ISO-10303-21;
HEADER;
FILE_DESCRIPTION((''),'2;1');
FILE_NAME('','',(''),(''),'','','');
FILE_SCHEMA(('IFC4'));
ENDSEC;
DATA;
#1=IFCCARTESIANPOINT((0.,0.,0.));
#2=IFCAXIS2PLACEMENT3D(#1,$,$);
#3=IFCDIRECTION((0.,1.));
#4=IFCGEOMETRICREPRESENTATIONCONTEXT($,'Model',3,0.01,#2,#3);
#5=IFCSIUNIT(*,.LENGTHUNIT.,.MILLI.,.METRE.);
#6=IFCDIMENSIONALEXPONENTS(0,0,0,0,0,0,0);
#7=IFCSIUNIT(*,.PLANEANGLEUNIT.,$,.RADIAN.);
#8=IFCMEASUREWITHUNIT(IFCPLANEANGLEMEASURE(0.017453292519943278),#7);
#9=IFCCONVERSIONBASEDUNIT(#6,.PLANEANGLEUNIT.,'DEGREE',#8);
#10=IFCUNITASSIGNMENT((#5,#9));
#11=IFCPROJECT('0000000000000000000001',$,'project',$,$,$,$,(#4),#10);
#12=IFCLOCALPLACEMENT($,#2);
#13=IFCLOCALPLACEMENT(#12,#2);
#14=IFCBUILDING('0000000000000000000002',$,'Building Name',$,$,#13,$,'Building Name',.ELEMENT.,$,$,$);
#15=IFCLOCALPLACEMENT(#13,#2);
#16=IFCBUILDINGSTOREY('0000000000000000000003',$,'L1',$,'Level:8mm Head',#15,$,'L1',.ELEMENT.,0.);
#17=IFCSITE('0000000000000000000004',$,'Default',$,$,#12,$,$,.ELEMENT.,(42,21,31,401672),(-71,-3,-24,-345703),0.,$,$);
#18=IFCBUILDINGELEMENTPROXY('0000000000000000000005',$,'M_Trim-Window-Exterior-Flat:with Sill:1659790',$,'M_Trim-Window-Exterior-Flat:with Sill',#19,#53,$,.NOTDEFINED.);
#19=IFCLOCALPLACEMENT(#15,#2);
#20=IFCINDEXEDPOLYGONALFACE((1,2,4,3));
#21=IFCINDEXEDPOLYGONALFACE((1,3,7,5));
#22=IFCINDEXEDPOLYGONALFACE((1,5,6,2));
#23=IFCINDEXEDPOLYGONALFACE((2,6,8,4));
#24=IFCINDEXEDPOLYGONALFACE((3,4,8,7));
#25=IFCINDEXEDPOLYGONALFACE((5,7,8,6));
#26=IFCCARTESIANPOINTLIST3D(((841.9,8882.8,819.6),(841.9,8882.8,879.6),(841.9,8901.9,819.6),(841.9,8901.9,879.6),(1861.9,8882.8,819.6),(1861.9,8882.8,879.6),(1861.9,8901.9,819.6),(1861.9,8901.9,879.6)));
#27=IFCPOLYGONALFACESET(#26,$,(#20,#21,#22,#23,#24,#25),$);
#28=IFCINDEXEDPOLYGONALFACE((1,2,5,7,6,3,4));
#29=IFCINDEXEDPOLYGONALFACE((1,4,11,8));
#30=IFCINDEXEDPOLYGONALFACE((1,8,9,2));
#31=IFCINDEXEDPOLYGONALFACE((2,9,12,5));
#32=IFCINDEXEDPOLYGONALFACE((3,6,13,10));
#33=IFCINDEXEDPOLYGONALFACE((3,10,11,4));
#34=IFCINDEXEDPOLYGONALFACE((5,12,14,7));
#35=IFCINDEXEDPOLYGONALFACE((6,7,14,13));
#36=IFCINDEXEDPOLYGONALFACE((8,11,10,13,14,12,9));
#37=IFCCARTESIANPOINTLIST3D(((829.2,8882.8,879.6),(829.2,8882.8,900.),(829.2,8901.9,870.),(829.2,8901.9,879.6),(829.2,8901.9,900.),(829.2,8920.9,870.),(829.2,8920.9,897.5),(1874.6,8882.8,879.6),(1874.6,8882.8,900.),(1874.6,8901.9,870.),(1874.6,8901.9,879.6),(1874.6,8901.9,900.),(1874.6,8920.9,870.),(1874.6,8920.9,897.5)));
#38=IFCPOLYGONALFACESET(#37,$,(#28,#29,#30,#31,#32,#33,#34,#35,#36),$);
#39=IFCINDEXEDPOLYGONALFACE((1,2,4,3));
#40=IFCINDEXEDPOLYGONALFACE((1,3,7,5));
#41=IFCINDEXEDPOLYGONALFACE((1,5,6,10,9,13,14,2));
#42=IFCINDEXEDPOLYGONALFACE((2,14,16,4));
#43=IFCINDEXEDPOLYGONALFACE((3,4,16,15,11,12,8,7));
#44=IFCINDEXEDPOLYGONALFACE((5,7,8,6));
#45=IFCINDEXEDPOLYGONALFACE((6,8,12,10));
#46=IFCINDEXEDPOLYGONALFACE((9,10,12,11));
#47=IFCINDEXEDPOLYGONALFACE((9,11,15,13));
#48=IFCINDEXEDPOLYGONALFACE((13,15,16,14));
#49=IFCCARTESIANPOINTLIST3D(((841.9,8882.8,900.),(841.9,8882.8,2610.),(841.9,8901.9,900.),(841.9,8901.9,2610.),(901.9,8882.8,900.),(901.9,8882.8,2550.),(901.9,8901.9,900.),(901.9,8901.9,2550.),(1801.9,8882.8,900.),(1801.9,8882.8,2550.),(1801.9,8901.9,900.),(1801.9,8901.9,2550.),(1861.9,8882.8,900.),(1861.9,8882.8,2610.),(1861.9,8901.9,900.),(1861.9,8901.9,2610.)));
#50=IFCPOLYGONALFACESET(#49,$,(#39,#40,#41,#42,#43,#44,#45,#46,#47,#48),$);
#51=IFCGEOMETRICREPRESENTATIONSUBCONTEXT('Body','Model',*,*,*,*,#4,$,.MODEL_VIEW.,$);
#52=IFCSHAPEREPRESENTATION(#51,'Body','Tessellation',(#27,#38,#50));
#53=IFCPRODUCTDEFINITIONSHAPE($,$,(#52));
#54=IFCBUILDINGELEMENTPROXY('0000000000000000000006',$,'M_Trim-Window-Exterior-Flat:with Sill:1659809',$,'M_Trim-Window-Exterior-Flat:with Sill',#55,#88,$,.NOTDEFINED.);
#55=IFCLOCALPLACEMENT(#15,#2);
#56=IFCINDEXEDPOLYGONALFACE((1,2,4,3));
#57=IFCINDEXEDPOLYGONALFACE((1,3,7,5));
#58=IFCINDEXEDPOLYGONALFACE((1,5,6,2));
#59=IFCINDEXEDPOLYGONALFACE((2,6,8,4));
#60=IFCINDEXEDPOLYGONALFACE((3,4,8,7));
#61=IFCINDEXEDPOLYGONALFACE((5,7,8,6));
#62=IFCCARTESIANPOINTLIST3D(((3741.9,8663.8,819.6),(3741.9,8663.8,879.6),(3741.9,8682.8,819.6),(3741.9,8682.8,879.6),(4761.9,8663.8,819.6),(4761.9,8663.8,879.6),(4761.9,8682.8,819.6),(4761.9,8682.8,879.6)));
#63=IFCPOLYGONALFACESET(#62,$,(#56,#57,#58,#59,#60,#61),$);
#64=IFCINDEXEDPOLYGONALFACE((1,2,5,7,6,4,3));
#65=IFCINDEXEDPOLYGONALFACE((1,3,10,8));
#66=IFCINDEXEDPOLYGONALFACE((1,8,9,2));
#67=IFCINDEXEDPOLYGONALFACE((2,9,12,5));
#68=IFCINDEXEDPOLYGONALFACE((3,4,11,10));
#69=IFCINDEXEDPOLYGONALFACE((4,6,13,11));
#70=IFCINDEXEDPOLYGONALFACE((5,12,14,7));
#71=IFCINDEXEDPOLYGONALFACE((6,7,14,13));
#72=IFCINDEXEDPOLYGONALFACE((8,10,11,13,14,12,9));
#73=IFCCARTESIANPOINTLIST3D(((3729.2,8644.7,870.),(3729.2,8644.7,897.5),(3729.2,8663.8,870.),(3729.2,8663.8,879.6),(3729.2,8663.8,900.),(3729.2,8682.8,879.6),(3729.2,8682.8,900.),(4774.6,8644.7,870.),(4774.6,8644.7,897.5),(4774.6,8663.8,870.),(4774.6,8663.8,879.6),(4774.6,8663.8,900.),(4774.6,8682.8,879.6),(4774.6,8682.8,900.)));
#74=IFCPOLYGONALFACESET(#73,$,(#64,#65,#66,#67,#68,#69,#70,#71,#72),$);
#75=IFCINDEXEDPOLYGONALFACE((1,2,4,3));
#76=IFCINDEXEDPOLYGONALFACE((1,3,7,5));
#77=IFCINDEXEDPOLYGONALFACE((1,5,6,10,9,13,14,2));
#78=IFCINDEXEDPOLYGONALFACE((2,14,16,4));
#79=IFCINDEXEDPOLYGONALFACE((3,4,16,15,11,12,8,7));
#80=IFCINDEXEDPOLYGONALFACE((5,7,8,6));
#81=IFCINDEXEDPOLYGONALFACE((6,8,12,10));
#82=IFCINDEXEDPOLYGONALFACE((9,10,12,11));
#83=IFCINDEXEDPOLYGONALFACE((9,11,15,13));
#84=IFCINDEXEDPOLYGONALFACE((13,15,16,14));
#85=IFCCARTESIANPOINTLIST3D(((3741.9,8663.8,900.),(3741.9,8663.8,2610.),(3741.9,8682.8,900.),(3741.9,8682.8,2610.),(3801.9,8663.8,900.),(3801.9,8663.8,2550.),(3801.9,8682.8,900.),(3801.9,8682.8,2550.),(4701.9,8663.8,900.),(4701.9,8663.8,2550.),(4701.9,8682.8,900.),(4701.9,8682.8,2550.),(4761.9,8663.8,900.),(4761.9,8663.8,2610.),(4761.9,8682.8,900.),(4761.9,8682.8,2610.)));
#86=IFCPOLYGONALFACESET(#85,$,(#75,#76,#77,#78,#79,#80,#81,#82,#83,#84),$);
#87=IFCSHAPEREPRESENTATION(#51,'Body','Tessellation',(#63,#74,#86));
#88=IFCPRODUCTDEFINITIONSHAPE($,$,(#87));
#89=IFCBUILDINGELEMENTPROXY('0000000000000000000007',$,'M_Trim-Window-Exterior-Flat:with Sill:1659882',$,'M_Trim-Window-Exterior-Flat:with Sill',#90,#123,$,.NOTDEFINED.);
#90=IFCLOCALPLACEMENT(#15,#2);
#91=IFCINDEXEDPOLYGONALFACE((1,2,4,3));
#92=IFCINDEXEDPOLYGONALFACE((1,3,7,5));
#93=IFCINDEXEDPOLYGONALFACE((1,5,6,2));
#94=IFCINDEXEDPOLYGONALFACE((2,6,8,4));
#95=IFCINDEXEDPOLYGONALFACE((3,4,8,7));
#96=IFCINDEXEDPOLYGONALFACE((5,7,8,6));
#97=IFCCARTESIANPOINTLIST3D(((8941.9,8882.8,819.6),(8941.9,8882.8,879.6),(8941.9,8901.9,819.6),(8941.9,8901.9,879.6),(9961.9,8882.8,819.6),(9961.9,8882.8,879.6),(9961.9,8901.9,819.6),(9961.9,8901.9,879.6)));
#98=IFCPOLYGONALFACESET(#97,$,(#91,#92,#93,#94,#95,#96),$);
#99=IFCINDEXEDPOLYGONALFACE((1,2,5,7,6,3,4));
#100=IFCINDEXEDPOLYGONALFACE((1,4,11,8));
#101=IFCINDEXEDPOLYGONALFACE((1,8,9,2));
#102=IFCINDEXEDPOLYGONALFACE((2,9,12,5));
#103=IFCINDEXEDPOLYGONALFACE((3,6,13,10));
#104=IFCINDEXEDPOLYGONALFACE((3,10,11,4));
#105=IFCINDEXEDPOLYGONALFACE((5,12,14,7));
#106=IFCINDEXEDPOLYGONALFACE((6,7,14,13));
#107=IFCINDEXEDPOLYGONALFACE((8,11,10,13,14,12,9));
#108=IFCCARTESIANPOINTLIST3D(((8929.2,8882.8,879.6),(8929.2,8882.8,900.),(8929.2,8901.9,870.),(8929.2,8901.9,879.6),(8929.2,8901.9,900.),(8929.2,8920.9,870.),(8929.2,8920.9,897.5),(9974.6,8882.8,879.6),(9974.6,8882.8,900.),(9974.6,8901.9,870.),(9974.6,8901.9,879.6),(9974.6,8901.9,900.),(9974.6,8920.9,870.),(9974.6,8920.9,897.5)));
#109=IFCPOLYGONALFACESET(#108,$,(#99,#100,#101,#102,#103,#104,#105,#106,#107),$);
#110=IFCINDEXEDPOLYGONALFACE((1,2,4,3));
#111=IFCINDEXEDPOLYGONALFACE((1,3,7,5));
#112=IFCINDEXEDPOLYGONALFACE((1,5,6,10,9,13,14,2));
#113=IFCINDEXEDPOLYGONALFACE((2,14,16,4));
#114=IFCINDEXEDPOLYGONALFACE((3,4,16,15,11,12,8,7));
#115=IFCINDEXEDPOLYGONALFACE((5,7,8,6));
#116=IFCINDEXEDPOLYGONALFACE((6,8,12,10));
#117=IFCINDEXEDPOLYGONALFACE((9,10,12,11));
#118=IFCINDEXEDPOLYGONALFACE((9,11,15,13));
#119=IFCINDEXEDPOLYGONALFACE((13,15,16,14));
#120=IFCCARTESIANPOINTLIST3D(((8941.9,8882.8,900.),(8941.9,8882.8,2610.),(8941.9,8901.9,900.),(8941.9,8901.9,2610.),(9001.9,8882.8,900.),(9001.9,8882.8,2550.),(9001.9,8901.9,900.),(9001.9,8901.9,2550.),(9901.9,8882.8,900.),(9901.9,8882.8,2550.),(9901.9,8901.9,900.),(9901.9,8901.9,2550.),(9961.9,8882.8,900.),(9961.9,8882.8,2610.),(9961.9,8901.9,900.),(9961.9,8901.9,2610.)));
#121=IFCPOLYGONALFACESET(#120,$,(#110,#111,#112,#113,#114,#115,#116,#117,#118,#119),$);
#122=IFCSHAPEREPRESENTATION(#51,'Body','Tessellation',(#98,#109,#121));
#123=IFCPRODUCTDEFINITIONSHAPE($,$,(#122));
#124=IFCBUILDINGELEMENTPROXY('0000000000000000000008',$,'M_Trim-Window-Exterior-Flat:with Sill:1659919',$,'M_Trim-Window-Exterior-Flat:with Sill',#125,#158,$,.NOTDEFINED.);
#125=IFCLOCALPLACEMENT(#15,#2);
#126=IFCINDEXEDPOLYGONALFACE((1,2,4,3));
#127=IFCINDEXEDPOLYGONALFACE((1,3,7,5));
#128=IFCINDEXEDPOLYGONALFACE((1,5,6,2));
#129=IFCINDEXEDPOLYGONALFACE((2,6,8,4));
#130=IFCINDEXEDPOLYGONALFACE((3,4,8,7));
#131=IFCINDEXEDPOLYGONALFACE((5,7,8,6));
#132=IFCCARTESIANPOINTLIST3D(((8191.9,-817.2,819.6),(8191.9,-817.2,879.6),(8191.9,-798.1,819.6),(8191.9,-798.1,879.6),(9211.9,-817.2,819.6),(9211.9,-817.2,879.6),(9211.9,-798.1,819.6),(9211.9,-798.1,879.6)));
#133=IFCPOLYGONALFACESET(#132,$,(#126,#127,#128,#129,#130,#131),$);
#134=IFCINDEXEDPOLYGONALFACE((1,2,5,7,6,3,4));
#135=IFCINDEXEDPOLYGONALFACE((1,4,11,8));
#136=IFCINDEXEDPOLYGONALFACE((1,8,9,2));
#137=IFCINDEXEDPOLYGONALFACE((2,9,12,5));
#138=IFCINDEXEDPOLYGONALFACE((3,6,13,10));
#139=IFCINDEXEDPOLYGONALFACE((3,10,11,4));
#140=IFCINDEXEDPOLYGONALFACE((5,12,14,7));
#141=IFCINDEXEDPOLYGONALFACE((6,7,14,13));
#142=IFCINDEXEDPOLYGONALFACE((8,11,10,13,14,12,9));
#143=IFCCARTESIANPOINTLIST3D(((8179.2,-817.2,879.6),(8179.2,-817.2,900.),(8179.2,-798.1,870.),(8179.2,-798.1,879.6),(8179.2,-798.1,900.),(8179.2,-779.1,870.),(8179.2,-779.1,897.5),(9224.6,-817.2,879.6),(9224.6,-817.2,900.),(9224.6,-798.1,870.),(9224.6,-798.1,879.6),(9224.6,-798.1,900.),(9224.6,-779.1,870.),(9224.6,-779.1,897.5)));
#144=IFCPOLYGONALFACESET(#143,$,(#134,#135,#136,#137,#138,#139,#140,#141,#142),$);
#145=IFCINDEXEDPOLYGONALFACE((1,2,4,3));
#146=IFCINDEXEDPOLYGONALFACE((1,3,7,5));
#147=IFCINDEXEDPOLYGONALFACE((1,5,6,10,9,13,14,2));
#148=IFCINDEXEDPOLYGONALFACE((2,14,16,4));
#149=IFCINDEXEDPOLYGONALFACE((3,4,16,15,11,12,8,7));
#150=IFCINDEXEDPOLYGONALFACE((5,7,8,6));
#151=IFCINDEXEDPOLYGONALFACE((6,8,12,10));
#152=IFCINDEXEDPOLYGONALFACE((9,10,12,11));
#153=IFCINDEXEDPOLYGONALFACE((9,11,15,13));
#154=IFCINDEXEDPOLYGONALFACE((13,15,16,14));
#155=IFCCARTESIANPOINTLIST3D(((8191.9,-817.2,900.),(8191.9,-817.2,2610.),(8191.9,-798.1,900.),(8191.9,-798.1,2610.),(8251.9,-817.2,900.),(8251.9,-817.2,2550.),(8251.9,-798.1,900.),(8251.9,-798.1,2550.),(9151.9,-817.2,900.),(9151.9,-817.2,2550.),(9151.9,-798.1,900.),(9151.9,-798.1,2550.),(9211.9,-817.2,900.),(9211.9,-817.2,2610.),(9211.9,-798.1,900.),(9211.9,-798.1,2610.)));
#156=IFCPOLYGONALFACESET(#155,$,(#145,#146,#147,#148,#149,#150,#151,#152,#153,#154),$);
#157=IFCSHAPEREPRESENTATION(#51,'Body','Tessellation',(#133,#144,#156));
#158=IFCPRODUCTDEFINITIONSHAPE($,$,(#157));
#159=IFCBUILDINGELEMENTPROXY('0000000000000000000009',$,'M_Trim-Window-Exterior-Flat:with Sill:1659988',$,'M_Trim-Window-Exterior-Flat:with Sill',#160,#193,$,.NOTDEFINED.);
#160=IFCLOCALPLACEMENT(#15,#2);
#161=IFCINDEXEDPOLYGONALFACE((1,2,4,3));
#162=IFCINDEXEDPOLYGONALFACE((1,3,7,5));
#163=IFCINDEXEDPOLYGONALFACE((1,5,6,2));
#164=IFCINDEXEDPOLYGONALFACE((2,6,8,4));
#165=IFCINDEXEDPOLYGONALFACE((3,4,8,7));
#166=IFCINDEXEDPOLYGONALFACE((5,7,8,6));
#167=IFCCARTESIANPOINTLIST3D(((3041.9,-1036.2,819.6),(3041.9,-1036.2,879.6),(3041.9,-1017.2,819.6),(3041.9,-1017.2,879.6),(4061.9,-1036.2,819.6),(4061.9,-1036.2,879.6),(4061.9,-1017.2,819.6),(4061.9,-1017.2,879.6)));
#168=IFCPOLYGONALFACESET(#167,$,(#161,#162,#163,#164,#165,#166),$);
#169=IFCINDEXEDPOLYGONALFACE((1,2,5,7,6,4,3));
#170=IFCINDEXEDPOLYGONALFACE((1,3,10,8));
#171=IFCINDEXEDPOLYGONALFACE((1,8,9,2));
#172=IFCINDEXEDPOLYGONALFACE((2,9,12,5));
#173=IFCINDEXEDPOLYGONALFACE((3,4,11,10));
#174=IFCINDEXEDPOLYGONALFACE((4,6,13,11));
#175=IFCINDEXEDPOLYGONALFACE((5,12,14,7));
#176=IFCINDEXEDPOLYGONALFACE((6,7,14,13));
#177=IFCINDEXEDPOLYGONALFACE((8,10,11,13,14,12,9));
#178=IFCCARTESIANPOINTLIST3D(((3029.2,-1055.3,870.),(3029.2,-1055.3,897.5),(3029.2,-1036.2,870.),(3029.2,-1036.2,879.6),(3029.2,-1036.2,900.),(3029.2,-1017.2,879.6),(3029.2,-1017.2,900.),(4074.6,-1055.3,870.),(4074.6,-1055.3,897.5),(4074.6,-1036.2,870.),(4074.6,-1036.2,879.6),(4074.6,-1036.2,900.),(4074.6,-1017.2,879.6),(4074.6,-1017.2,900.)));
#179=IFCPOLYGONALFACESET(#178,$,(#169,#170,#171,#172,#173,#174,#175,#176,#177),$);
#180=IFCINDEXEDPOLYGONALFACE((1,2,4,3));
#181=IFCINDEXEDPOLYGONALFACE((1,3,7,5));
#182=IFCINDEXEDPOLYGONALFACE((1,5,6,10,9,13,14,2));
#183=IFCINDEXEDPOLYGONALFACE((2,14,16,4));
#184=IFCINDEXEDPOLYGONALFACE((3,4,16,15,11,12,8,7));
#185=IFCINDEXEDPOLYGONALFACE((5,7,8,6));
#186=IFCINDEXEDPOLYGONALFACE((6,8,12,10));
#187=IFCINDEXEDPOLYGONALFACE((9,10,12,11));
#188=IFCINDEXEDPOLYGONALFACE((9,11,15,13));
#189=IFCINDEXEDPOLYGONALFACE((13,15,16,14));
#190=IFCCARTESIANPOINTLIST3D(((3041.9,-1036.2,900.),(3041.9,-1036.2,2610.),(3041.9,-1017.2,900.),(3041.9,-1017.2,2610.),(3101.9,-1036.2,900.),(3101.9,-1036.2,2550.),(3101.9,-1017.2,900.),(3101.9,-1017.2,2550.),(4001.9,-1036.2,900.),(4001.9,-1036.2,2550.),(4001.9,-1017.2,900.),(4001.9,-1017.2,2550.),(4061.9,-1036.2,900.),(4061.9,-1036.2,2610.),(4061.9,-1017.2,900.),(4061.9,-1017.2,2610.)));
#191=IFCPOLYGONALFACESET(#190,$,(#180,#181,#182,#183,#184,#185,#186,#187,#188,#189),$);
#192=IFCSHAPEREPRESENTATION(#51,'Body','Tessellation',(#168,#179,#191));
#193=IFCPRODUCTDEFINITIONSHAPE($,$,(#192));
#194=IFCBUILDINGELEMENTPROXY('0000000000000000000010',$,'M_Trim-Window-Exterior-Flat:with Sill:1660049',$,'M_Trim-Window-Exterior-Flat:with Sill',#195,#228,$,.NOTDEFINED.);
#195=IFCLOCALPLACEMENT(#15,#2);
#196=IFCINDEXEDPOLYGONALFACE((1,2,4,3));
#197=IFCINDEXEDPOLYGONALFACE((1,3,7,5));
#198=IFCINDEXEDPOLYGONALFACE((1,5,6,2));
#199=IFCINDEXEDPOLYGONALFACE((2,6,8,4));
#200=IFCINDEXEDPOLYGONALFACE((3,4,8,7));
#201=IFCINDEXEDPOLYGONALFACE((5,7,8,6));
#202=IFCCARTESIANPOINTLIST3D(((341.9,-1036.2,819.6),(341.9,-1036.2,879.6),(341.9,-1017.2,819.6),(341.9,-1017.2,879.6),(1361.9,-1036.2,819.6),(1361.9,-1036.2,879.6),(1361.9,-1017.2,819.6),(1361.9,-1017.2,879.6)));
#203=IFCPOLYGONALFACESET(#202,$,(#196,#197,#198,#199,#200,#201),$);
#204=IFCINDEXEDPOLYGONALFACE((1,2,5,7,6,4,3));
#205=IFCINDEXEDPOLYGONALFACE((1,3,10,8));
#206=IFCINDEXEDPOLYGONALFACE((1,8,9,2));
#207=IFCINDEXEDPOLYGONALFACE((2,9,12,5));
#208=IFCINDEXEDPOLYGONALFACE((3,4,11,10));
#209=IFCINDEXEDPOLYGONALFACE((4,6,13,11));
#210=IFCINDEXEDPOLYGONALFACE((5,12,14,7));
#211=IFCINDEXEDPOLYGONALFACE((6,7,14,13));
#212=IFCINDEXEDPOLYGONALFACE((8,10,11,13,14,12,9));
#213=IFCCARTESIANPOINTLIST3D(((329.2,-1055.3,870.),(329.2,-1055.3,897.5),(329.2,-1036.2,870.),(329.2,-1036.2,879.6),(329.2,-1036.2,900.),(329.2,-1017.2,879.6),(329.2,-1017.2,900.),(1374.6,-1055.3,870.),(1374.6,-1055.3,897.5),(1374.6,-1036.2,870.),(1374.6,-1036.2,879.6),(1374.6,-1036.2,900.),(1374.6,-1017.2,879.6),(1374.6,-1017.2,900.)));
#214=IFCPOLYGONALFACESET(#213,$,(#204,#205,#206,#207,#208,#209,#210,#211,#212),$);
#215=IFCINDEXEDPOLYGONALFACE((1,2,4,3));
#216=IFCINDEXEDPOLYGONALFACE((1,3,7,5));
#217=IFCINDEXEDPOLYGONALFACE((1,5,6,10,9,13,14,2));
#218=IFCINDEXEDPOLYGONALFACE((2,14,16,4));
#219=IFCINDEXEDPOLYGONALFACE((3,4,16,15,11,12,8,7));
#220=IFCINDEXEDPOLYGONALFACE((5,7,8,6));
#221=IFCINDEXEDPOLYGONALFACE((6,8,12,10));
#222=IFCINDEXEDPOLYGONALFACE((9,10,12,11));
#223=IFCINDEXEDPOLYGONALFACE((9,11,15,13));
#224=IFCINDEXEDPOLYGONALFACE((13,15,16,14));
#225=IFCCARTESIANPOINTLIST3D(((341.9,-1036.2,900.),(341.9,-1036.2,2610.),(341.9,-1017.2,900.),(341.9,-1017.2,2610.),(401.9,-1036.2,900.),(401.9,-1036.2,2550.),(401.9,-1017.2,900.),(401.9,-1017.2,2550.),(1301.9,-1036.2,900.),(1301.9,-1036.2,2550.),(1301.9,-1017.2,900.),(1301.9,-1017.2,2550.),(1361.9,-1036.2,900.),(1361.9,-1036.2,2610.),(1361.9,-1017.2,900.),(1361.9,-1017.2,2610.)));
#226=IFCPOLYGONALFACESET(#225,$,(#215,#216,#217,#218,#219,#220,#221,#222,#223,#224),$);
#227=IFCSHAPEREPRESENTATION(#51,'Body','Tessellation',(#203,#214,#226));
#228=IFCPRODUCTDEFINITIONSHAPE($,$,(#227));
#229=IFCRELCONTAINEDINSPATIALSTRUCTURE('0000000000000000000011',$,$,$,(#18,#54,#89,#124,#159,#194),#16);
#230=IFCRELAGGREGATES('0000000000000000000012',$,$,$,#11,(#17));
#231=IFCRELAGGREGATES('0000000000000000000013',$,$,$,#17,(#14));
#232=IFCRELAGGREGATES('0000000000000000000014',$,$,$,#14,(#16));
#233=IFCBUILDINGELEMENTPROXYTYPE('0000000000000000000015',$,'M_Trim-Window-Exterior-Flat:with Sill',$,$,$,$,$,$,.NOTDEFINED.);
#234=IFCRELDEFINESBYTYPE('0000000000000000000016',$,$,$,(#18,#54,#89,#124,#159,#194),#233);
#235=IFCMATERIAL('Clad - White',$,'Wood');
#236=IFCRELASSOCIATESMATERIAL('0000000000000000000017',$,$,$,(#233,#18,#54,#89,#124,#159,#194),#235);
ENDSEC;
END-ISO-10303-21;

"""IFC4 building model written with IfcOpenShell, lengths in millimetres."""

from ifc_helpers import new_model, entity, si_unit, converted_unit, direction, frame, origin, place, context, subcontext, project, spatial, indexed_curve, outline, extrude, source, transform, mapped, material, type_object, type_shapes, element, save


model = new_model("IFC4")

# Units and contexts
model_context = context("Model", 3, precision=0.01, world=origin(), true_north=direction((0.0, 1.0)))
body_context = subcontext(model_context, "Body", "Model", "MODEL_VIEW")
ifc_project = project(units=[si_unit("LENGTHUNIT", "METRE", prefix="MILLI"), converted_unit("PLANEANGLEUNIT", "DEGREE", entity("IfcPlaneAngleMeasure", 0.017453292519943278), si_unit("PLANEANGLEUNIT", "RADIAN"), dimensions=[0, 0, 0, 0, 0, 0, 0])], contexts=[model_context])

# Site, building, storey
site_placement = place(None, origin())
site = spatial("IfcSite", under=ifc_project, at=site_placement, Name="Default", CompositionType="ELEMENT", RefLatitude=(42, 21, 31, 401672), RefLongitude=(-71, -3, -24, -345703), RefElevation=0.0)
building_placement = place(site_placement, origin())
building = spatial("IfcBuilding", under=site, at=building_placement, Name="Building Name", LongName="Building Name", CompositionType="ELEMENT")
storey_placement = place(building_placement, origin())
storey = spatial("IfcBuildingStorey", under=building, at=storey_placement, Name="L1", ObjectType="Level:8mm Head", LongName="L1", CompositionType="ELEMENT", Elevation=0.0)

# Building element proxies
ifc_material_1 = material(Name="Clad - White", Category="Wood")
building_element_proxy_type_1 = type_object("IfcBuildingElementProxyType", Name="M_Trim-Window-Exterior-Flat:with Sill", PredefinedType="NOTDEFINED", material=ifc_material_1)
shared_shape_1 = source(origin(), body_context, "Body", "SweptSolid", [
    extrude(outline(indexed_curve([(-510.0, -30.0), (510.0, -30.0), (510.0, 30.0), (-510.0, 30.0), (-510.0, -30.0)], self_intersect=False)), frame((0.0, -1700.4, 0.0), z_axis=(0.0, 0.0, 1.0), x_axis=(-1.0, 0.0, 0.0)), (0.0, 0.0, 1.0), 19.0),
    extrude(outline(indexed_curve([(-19.0, -15.2), (0.0, -15.2), (0.0, -5.7), (19.0, -5.7), (19.0, 14.8), (0.0, 14.8), (-19.0, 12.3), (-19.0, -15.2)], self_intersect=False)), frame((-522.7, -1664.8, 19.0), z_axis=(1.0, 0.0, 0.0), x_axis=(0.0, 0.0, -1.0)), (0.0, 0.0, 1.0), 1045.4),
    extrude(outline(indexed_curve([(-870.0, -510.0), (840.0, -510.0), (840.0, -450.0), (-810.0, -450.0), (-810.0, 450.0), (840.0, 450.0), (840.0, 510.0), (-870.0, 510.0), (-870.0, -510.0)], self_intersect=False)), frame((0.0, -810.0, 0.0), z_axis=(0.0, 0.0, 1.0), x_axis=(0.0, -1.0, 0.0)), (0.0, 0.0, 1.0), 19.0),
])
type_shapes(building_element_proxy_type_1, [shared_shape_1])
for number, where, z_axis, x_axis, name in (
    (1, (1351.9, 8882.8, 2550.0), (0.0, 1.0, 0.0), (-1.0, 0.0, 0.0), "M_Trim-Window-Exterior-Flat:with Sill:1659790"),
    (2, (4251.9, 8682.8, 2550.0), (0.0, -1.0, 0.0), (1.0, 0.0, 0.0), "M_Trim-Window-Exterior-Flat:with Sill:1659809"),
    (3, (9451.9, 8882.8, 2550.0), (0.0, 1.0, 0.0), (-1.0, 0.0, 0.0), "M_Trim-Window-Exterior-Flat:with Sill:1659882"),
    (4, (8701.9, -817.2, 2550.0), (0.0, 1.0, 0.0), (-1.0, 0.0, 0.0), "M_Trim-Window-Exterior-Flat:with Sill:1659919"),
    (5, (3551.9, -1017.2, 2550.0), (0.0, -1.0, 0.0), (1.0, 0.0, 0.0), "M_Trim-Window-Exterior-Flat:with Sill:1659988"),
    (6, (851.9, -1017.2, 2550.0), (0.0, -1.0, 0.0), (1.0, 0.0, 0.0), "M_Trim-Window-Exterior-Flat:with Sill:1660049"),
):
    element("IfcBuildingElementProxy", number, at=place(storey_placement, frame(where, z_axis=z_axis, x_axis=x_axis)), inside=storey, type_object=building_element_proxy_type_1, material=ifc_material_1, Name=name, ObjectType="M_Trim-Window-Exterior-Flat:with Sill", PredefinedType="NOTDEFINED", context=body_context, shape_type="MappedRepresentation", body=[
        mapped(shared_shape_1, transform((0.0, 0.0, 0.0), scale=1.0)),
    ])

save(model, "model.ifc")
